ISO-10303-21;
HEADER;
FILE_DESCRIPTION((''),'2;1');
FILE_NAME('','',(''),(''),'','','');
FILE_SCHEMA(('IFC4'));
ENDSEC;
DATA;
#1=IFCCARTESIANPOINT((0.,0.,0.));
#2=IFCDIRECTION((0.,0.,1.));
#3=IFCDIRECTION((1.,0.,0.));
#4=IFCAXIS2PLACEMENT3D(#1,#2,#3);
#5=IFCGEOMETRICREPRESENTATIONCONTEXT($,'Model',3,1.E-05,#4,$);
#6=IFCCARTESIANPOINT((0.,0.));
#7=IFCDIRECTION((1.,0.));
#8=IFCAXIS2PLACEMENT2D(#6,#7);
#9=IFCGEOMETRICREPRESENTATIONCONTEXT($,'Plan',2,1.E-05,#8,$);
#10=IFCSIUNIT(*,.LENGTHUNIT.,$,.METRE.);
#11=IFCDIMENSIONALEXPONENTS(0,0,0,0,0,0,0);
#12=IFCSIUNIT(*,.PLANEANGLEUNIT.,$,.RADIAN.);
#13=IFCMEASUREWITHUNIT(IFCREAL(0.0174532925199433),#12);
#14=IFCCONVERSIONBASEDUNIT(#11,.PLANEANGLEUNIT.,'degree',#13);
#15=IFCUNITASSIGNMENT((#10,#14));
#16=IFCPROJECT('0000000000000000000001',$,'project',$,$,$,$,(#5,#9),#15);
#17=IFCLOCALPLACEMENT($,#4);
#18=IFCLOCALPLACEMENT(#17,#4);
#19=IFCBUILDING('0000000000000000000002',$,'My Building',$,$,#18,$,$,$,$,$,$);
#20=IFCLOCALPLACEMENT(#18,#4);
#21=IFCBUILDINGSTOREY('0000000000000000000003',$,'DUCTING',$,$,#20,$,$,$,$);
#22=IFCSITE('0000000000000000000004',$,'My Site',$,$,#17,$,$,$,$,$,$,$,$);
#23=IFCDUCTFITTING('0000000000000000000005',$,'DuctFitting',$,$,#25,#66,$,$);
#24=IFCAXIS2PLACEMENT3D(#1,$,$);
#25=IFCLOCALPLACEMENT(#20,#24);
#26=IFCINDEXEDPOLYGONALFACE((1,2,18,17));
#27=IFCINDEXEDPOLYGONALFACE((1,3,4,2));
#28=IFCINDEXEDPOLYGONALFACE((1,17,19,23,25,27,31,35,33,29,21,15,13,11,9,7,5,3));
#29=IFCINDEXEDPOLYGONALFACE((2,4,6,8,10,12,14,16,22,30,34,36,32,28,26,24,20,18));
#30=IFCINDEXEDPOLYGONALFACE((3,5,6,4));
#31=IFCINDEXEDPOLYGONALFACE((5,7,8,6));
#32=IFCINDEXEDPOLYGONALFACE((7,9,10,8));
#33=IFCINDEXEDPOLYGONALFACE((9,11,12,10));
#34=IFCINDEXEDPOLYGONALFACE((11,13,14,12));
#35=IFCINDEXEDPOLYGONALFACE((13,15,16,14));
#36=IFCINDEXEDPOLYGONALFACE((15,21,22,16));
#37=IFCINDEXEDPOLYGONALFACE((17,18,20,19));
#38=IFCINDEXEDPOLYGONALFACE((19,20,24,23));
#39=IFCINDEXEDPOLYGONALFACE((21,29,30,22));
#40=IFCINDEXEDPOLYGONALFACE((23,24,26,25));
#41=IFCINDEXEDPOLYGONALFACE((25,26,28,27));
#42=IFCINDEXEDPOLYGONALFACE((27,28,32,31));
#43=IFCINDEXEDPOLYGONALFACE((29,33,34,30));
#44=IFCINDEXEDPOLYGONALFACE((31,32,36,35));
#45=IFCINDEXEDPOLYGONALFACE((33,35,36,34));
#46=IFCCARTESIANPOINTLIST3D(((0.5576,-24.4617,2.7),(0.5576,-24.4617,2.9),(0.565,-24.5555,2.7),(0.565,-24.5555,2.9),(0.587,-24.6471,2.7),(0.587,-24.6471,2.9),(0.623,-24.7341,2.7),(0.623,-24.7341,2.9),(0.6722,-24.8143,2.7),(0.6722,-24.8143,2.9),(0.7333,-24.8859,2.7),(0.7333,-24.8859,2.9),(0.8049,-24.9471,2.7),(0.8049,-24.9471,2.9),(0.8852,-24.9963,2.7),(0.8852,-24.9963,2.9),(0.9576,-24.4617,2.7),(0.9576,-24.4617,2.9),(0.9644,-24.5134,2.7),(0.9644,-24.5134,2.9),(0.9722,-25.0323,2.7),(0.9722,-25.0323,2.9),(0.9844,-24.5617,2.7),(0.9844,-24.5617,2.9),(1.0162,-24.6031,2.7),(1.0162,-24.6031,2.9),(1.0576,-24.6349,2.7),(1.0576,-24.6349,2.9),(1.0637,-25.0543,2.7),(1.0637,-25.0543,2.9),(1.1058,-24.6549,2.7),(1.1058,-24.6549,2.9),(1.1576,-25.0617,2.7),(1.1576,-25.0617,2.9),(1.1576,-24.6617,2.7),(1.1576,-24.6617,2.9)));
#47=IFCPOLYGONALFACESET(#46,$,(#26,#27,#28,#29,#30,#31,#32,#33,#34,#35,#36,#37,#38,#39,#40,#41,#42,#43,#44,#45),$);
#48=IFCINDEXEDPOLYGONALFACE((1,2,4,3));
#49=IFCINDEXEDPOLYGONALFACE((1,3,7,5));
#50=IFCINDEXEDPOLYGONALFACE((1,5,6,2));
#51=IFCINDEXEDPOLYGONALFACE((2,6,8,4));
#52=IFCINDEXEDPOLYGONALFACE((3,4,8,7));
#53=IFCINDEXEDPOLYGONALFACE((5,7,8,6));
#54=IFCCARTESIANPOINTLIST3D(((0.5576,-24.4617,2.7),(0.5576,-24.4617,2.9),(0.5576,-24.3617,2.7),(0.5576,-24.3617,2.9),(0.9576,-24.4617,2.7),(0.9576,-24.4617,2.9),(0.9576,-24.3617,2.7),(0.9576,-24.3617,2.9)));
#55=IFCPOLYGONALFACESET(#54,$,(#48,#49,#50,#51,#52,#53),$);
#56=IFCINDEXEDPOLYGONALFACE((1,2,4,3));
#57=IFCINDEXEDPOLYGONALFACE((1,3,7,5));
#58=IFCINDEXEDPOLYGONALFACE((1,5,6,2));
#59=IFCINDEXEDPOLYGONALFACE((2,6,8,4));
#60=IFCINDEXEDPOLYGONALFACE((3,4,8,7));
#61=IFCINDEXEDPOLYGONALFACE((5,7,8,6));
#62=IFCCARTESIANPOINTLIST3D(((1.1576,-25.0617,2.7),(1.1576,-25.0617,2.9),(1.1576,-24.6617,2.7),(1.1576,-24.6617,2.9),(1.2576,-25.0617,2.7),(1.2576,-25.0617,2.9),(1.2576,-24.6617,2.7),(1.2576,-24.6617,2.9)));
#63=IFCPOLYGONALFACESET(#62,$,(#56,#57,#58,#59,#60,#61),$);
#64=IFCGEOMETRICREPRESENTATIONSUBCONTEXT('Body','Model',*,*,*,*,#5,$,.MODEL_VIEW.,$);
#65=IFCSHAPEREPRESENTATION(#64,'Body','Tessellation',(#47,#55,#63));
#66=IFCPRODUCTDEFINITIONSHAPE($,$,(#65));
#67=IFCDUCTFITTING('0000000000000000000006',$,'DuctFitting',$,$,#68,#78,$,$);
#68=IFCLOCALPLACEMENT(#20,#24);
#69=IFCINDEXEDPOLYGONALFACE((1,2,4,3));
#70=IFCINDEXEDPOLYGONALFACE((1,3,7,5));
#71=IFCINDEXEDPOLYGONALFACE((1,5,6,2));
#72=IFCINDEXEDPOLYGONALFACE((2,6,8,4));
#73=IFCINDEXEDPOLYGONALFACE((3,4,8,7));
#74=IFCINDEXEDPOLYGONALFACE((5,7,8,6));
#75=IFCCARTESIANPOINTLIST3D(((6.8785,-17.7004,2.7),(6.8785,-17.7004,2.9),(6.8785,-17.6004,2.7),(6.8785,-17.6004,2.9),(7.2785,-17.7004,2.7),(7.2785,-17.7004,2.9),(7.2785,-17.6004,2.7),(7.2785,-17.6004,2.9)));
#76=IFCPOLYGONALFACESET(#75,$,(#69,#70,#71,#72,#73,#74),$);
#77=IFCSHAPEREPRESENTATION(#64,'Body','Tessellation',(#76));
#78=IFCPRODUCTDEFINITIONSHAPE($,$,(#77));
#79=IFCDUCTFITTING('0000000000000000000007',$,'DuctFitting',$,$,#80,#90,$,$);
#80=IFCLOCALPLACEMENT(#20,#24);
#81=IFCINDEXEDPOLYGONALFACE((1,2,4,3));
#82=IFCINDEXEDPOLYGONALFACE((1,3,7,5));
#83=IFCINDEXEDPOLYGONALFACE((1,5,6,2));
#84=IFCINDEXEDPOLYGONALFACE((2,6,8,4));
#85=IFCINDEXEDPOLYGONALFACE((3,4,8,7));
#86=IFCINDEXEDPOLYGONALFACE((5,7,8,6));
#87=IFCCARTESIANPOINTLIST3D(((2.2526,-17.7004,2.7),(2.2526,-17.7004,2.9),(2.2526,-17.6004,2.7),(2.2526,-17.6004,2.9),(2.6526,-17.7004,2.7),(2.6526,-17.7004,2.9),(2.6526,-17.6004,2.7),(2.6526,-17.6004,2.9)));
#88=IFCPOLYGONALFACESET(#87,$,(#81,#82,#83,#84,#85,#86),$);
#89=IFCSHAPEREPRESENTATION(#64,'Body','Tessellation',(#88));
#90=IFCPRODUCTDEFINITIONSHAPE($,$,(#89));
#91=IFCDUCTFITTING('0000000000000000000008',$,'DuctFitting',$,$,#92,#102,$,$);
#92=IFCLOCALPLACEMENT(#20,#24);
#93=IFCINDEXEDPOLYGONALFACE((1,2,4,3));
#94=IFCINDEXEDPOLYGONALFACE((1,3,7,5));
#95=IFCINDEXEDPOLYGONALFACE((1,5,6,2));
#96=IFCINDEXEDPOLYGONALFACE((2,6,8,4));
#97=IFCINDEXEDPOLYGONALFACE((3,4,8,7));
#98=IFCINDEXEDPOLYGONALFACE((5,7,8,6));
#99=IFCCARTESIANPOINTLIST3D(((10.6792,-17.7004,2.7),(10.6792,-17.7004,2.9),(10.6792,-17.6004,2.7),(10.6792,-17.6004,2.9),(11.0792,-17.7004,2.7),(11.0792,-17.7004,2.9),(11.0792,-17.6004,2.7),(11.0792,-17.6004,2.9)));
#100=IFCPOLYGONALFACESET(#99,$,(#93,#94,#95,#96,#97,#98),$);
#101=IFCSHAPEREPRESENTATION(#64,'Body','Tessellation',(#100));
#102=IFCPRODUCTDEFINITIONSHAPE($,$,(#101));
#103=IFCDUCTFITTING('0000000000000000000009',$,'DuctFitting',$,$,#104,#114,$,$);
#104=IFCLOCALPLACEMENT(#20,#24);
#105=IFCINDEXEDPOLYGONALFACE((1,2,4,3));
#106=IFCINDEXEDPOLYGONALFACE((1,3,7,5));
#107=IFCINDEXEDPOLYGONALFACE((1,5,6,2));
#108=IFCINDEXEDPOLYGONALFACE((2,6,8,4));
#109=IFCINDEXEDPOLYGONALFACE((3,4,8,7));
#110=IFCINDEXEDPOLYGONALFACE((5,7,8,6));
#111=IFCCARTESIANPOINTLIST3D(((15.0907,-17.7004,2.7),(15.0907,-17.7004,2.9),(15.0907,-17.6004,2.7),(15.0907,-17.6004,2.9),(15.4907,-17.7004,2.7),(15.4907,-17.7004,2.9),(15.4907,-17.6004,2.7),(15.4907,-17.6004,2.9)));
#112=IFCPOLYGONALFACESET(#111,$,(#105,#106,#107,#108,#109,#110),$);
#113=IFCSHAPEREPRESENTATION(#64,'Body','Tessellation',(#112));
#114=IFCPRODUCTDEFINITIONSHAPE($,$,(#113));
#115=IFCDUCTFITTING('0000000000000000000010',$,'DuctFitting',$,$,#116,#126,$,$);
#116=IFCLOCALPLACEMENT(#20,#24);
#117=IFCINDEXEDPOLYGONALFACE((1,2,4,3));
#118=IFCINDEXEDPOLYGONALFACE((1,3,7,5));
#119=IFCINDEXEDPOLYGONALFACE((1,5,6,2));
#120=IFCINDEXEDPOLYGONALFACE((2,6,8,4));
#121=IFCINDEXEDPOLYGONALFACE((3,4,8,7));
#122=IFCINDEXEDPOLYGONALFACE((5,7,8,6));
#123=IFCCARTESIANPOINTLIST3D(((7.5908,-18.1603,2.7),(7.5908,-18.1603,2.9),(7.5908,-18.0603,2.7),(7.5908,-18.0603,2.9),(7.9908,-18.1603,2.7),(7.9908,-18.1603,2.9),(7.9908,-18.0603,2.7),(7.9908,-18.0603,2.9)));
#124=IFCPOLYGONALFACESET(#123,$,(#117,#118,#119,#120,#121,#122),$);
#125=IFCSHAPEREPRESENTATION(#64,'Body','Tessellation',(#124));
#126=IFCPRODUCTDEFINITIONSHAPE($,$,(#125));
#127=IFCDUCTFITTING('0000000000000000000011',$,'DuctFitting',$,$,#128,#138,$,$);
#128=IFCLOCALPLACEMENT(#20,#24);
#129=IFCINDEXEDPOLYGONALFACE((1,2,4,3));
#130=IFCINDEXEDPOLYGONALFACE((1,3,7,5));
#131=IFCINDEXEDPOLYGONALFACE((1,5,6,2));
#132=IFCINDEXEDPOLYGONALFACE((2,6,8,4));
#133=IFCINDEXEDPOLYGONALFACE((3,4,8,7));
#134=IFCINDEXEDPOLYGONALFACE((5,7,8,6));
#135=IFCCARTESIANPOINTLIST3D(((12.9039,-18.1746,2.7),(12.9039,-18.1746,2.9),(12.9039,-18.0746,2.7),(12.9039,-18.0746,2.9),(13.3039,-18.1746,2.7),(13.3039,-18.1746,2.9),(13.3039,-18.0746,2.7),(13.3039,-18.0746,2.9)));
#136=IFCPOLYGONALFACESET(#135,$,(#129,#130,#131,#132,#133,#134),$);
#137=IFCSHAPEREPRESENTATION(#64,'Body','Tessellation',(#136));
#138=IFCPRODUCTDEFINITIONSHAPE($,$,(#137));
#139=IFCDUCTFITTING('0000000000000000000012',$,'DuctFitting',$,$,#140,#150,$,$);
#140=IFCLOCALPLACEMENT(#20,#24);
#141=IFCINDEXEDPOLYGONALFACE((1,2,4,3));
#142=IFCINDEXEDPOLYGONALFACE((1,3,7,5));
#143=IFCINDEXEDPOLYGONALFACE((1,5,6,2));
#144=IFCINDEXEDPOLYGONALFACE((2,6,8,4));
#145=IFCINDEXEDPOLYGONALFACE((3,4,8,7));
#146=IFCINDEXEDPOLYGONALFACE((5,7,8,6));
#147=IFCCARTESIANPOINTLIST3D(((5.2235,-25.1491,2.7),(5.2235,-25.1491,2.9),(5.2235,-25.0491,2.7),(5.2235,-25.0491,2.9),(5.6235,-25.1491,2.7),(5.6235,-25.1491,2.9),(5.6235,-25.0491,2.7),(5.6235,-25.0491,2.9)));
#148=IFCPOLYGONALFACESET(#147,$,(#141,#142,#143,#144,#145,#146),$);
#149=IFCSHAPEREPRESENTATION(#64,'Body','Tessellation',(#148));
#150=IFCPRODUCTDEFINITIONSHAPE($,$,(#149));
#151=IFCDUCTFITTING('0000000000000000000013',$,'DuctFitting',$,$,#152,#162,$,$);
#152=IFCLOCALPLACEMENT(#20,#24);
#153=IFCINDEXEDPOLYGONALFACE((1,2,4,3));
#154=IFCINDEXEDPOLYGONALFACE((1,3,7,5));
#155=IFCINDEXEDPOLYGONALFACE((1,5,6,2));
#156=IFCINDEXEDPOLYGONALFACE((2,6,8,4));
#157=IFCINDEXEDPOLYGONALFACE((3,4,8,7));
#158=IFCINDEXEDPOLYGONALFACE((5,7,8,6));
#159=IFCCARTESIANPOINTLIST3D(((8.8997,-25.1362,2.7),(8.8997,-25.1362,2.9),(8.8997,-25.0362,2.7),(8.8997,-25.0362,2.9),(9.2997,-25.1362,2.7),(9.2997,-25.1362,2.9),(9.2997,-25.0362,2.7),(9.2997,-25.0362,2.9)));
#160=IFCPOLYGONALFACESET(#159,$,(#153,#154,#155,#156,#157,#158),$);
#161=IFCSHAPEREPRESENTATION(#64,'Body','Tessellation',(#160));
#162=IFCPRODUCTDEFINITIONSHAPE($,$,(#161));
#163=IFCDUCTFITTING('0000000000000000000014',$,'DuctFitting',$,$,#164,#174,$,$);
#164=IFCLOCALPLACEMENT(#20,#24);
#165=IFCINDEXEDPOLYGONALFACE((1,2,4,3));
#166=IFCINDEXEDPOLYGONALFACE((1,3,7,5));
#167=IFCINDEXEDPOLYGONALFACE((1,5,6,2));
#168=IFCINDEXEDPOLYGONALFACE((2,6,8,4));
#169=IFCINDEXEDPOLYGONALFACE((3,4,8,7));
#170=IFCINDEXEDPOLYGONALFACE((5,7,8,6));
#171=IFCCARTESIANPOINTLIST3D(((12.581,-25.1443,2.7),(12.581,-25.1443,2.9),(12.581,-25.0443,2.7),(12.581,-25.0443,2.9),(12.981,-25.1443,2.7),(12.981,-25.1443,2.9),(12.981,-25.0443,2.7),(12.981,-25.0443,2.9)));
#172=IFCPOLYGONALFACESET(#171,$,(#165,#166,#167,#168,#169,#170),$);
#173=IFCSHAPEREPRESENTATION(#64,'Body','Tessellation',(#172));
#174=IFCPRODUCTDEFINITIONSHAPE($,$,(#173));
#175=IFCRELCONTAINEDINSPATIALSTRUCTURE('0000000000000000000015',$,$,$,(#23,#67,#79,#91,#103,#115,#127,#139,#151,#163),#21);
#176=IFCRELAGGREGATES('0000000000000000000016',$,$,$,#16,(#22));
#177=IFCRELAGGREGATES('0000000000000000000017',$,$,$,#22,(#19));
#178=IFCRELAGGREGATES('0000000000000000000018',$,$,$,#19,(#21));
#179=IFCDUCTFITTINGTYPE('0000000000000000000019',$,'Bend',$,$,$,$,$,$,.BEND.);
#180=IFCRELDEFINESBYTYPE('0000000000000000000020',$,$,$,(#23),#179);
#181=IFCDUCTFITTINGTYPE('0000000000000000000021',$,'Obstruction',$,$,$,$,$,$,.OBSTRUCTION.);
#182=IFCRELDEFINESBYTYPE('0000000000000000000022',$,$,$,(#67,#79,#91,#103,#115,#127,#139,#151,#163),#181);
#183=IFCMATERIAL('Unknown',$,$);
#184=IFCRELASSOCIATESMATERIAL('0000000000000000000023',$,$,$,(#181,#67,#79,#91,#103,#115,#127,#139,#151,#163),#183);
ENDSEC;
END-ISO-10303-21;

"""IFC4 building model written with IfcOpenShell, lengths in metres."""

from ifc_helpers import new_model, entity, si_unit, converted_unit, frame, origin_with_axes, origin_2d_with_axis, place, context, subcontext, project, spatial, line, arc, indexed_curve, rectangle, outline, extrude, source, transform, mapped, material, material_profile, profile_set, profile_usage, type_object, type_shapes, element, save


model = new_model("IFC4")

# Units and contexts
model_context = context("Model", 3, precision=1e-05, world=origin_with_axes())
plan_context = context("Plan", 2, precision=1e-05, world=origin_2d_with_axis())
body_context = subcontext(model_context, "Body", "Model", "MODEL_VIEW")
ifc_project = project(units=[si_unit("LENGTHUNIT", "METRE"), converted_unit("PLANEANGLEUNIT", "degree", entity("IfcReal", 0.0174532925199433), si_unit("PLANEANGLEUNIT", "RADIAN"), dimensions=[0, 0, 0, 0, 0, 0, 0])], contexts=[model_context, plan_context])

# Site, building, storey
site_placement = place(None, origin_with_axes())
site = spatial("IfcSite", under=ifc_project, at=site_placement, Name="My Site")
building_placement = place(site_placement, origin_with_axes())
building = spatial("IfcBuilding", under=site, at=building_placement, Name="My Building")
storey_placement = place(building_placement, origin_with_axes())
storey = spatial("IfcBuildingStorey", under=building, at=storey_placement, Name="DUCTING")

# Shared definitions
ifc_material = material(Name="Unknown")

# Duct fittings
duct_fitting_type_1 = type_object("IfcDuctFittingType", Name="Bend", PredefinedType="BEND")
shared_shape = source(origin_with_axes(), body_context, "Body", "SweptSolid", [
    extrude(outline(indexed_curve([(-0.2, 0.0), (-0.2586, 0.1414), (-0.4, 0.2), (-0.4, 0.6), (0.0243, 0.4243), (0.2, 0.0)], segments=[arc(1, 2, 3), line(3, 4), arc(4, 5, 6), line(6, 1)])), frame((0.0, -0.1, 0.1), z_axis=(0.0, -1.0, 0.0), x_axis=(1.0, 0.0, 0.0)), (0.0, 0.0, -1.0), 0.2),
    extrude(rectangle(XDim=0.4, YDim=0.2), origin_with_axes(), (0.0, 0.0, 1.0), 0.1),
    extrude(rectangle(XDim=0.4, YDim=0.2), frame((-0.4, 0.0, 0.5), z_axis=(-1.0, 0.0, 0.0), x_axis=(0.0, 0.0, -1.0)), (0.0, 0.0, 1.0), 0.1),
])
type_shapes(duct_fitting_type_1, [shared_shape])
for number, where, z_axis, x_axis, name in (
    (1, (0.7576, -24.3617, 2.8), (0.0, -1.0, 0.0), (-1.0, 0.0, 0.0), "DuctFitting"),
):
    element("IfcDuctFitting", number, at=place(storey_placement, frame(where, z_axis=z_axis, x_axis=x_axis)), inside=storey, type_object=duct_fitting_type_1, Name=name, context=body_context, shape_type="MappedRepresentation", body=[
        mapped(shared_shape, transform((0.0, 0.0, 0.0), x_axis=(1.0, 0.0, 0.0), y_axis=(0.0, 1.0, 0.0), z_axis=(0.0, 0.0, 1.0), scale=1.0)),
    ])
ifc_material_profile_1 = material_profile(ifc_material, rectangle(XDim=0.4, YDim=0.2))
ifc_profile_set_1 = profile_set([ifc_material_profile_1])
ifc_profile_usage_1 = profile_usage(ifc_profile_set_1, cardinal=5)
duct_fitting_type_2 = type_object("IfcDuctFittingType", Name="Obstruction", PredefinedType="OBSTRUCTION", material=ifc_profile_set_1)
duct_fitting_1_placement = place(storey_placement, frame((7.0785, -17.7004, 2.8), z_axis=(0.0, 1.0, 0.0), x_axis=(-1.0, 0.0, 0.0)))
element("IfcDuctFitting", 2, at=duct_fitting_1_placement, inside=storey, type_object=duct_fitting_type_2, material=ifc_profile_usage_1, Name="DuctFitting", context=body_context, shape_type="SweptSolid", body=[
    extrude(rectangle(XDim=0.4, YDim=0.2), origin_with_axes(), (0.0, 0.0, 1.0), 0.1),
])
ifc_profile_usage_2 = profile_usage(ifc_profile_set_1, cardinal=5)
duct_fitting_2_placement = place(storey_placement, frame((2.4526, -17.7004, 2.8), z_axis=(0.0, 1.0, 0.0), x_axis=(-1.0, 0.0, 0.0)))
element("IfcDuctFitting", 3, at=duct_fitting_2_placement, inside=storey, type_object=duct_fitting_type_2, material=ifc_profile_usage_2, Name="DuctFitting", context=body_context, shape_type="SweptSolid", body=[
    extrude(rectangle(XDim=0.4, YDim=0.2), origin_with_axes(), (0.0, 0.0, 1.0), 0.1),
])
ifc_profile_usage_3 = profile_usage(ifc_profile_set_1, cardinal=5)
duct_fitting_3_placement = place(storey_placement, frame((10.8792, -17.7004, 2.8), z_axis=(0.0, 1.0, 0.0), x_axis=(-1.0, 0.0, 0.0)))
element("IfcDuctFitting", 4, at=duct_fitting_3_placement, inside=storey, type_object=duct_fitting_type_2, material=ifc_profile_usage_3, Name="DuctFitting", context=body_context, shape_type="SweptSolid", body=[
    extrude(rectangle(XDim=0.4, YDim=0.2), origin_with_axes(), (0.0, 0.0, 1.0), 0.1),
])
ifc_profile_usage_4 = profile_usage(ifc_profile_set_1, cardinal=5)
duct_fitting_4_placement = place(storey_placement, frame((15.2907, -17.7004, 2.8), z_axis=(0.0, 1.0, 0.0), x_axis=(-1.0, 0.0, 0.0)))
element("IfcDuctFitting", 5, at=duct_fitting_4_placement, inside=storey, type_object=duct_fitting_type_2, material=ifc_profile_usage_4, Name="DuctFitting", context=body_context, shape_type="SweptSolid", body=[
    extrude(rectangle(XDim=0.4, YDim=0.2), origin_with_axes(), (0.0, 0.0, 1.0), 0.1),
])
ifc_profile_usage_5 = profile_usage(ifc_profile_set_1, cardinal=5)
duct_fitting_5_placement = place(storey_placement, frame((7.7908, -18.1603, 2.8), z_axis=(-0.000001, 1.0, 0.0), x_axis=(-1.0, -0.000001, 0.0)))
element("IfcDuctFitting", 6, at=duct_fitting_5_placement, inside=storey, type_object=duct_fitting_type_2, material=ifc_profile_usage_5, Name="DuctFitting", context=body_context, shape_type="SweptSolid", body=[
    extrude(rectangle(XDim=0.4, YDim=0.2), origin_with_axes(), (0.0, 0.0, 1.0), 0.1),
])
ifc_profile_usage_6 = profile_usage(ifc_profile_set_1, cardinal=5)
duct_fitting_6_placement = place(storey_placement, frame((13.1039, -18.1746, 2.8), z_axis=(-0.000001, 1.0, 0.0), x_axis=(-1.0, -0.000001, 0.0)))
element("IfcDuctFitting", 7, at=duct_fitting_6_placement, inside=storey, type_object=duct_fitting_type_2, material=ifc_profile_usage_6, Name="DuctFitting", context=body_context, shape_type="SweptSolid", body=[
    extrude(rectangle(XDim=0.4, YDim=0.2), origin_with_axes(), (0.0, 0.0, 1.0), 0.1),
])
ifc_profile_usage_7 = profile_usage(ifc_profile_set_1, cardinal=5)
duct_fitting_7_placement = place(storey_placement, frame((5.4235, -25.0491, 2.8), z_axis=(0.0, -1.0, 0.0), x_axis=(1.0, 0.0, 0.0)))
element("IfcDuctFitting", 8, at=duct_fitting_7_placement, inside=storey, type_object=duct_fitting_type_2, material=ifc_profile_usage_7, Name="DuctFitting", context=body_context, shape_type="SweptSolid", body=[
    extrude(rectangle(XDim=0.4, YDim=0.2), origin_with_axes(), (0.0, 0.0, 1.0), 0.1),
])
ifc_profile_usage_8 = profile_usage(ifc_profile_set_1, cardinal=5)
duct_fitting_8_placement = place(storey_placement, frame((9.0997, -25.1362, 2.8), z_axis=(0.0, 1.0, 0.0), x_axis=(-1.0, 0.0, 0.0)))
element("IfcDuctFitting", 9, at=duct_fitting_8_placement, inside=storey, type_object=duct_fitting_type_2, material=ifc_profile_usage_8, Name="DuctFitting", context=body_context, shape_type="SweptSolid", body=[
    extrude(rectangle(XDim=0.4, YDim=0.2), origin_with_axes(), (0.0, 0.0, 1.0), 0.1),
])
ifc_profile_usage_9 = profile_usage(ifc_profile_set_1, cardinal=5)
duct_fitting_9_placement = place(storey_placement, frame((12.781, -25.1443, 2.8), z_axis=(0.0, 1.0, 0.0), x_axis=(-1.0, 0.0, 0.0)))
element("IfcDuctFitting", 10, at=duct_fitting_9_placement, inside=storey, type_object=duct_fitting_type_2, material=ifc_profile_usage_9, Name="DuctFitting", context=body_context, shape_type="SweptSolid", body=[
    extrude(rectangle(XDim=0.4, YDim=0.2), origin_with_axes(), (0.0, 0.0, 1.0), 0.1),
])

save(model, "model.ifc")
